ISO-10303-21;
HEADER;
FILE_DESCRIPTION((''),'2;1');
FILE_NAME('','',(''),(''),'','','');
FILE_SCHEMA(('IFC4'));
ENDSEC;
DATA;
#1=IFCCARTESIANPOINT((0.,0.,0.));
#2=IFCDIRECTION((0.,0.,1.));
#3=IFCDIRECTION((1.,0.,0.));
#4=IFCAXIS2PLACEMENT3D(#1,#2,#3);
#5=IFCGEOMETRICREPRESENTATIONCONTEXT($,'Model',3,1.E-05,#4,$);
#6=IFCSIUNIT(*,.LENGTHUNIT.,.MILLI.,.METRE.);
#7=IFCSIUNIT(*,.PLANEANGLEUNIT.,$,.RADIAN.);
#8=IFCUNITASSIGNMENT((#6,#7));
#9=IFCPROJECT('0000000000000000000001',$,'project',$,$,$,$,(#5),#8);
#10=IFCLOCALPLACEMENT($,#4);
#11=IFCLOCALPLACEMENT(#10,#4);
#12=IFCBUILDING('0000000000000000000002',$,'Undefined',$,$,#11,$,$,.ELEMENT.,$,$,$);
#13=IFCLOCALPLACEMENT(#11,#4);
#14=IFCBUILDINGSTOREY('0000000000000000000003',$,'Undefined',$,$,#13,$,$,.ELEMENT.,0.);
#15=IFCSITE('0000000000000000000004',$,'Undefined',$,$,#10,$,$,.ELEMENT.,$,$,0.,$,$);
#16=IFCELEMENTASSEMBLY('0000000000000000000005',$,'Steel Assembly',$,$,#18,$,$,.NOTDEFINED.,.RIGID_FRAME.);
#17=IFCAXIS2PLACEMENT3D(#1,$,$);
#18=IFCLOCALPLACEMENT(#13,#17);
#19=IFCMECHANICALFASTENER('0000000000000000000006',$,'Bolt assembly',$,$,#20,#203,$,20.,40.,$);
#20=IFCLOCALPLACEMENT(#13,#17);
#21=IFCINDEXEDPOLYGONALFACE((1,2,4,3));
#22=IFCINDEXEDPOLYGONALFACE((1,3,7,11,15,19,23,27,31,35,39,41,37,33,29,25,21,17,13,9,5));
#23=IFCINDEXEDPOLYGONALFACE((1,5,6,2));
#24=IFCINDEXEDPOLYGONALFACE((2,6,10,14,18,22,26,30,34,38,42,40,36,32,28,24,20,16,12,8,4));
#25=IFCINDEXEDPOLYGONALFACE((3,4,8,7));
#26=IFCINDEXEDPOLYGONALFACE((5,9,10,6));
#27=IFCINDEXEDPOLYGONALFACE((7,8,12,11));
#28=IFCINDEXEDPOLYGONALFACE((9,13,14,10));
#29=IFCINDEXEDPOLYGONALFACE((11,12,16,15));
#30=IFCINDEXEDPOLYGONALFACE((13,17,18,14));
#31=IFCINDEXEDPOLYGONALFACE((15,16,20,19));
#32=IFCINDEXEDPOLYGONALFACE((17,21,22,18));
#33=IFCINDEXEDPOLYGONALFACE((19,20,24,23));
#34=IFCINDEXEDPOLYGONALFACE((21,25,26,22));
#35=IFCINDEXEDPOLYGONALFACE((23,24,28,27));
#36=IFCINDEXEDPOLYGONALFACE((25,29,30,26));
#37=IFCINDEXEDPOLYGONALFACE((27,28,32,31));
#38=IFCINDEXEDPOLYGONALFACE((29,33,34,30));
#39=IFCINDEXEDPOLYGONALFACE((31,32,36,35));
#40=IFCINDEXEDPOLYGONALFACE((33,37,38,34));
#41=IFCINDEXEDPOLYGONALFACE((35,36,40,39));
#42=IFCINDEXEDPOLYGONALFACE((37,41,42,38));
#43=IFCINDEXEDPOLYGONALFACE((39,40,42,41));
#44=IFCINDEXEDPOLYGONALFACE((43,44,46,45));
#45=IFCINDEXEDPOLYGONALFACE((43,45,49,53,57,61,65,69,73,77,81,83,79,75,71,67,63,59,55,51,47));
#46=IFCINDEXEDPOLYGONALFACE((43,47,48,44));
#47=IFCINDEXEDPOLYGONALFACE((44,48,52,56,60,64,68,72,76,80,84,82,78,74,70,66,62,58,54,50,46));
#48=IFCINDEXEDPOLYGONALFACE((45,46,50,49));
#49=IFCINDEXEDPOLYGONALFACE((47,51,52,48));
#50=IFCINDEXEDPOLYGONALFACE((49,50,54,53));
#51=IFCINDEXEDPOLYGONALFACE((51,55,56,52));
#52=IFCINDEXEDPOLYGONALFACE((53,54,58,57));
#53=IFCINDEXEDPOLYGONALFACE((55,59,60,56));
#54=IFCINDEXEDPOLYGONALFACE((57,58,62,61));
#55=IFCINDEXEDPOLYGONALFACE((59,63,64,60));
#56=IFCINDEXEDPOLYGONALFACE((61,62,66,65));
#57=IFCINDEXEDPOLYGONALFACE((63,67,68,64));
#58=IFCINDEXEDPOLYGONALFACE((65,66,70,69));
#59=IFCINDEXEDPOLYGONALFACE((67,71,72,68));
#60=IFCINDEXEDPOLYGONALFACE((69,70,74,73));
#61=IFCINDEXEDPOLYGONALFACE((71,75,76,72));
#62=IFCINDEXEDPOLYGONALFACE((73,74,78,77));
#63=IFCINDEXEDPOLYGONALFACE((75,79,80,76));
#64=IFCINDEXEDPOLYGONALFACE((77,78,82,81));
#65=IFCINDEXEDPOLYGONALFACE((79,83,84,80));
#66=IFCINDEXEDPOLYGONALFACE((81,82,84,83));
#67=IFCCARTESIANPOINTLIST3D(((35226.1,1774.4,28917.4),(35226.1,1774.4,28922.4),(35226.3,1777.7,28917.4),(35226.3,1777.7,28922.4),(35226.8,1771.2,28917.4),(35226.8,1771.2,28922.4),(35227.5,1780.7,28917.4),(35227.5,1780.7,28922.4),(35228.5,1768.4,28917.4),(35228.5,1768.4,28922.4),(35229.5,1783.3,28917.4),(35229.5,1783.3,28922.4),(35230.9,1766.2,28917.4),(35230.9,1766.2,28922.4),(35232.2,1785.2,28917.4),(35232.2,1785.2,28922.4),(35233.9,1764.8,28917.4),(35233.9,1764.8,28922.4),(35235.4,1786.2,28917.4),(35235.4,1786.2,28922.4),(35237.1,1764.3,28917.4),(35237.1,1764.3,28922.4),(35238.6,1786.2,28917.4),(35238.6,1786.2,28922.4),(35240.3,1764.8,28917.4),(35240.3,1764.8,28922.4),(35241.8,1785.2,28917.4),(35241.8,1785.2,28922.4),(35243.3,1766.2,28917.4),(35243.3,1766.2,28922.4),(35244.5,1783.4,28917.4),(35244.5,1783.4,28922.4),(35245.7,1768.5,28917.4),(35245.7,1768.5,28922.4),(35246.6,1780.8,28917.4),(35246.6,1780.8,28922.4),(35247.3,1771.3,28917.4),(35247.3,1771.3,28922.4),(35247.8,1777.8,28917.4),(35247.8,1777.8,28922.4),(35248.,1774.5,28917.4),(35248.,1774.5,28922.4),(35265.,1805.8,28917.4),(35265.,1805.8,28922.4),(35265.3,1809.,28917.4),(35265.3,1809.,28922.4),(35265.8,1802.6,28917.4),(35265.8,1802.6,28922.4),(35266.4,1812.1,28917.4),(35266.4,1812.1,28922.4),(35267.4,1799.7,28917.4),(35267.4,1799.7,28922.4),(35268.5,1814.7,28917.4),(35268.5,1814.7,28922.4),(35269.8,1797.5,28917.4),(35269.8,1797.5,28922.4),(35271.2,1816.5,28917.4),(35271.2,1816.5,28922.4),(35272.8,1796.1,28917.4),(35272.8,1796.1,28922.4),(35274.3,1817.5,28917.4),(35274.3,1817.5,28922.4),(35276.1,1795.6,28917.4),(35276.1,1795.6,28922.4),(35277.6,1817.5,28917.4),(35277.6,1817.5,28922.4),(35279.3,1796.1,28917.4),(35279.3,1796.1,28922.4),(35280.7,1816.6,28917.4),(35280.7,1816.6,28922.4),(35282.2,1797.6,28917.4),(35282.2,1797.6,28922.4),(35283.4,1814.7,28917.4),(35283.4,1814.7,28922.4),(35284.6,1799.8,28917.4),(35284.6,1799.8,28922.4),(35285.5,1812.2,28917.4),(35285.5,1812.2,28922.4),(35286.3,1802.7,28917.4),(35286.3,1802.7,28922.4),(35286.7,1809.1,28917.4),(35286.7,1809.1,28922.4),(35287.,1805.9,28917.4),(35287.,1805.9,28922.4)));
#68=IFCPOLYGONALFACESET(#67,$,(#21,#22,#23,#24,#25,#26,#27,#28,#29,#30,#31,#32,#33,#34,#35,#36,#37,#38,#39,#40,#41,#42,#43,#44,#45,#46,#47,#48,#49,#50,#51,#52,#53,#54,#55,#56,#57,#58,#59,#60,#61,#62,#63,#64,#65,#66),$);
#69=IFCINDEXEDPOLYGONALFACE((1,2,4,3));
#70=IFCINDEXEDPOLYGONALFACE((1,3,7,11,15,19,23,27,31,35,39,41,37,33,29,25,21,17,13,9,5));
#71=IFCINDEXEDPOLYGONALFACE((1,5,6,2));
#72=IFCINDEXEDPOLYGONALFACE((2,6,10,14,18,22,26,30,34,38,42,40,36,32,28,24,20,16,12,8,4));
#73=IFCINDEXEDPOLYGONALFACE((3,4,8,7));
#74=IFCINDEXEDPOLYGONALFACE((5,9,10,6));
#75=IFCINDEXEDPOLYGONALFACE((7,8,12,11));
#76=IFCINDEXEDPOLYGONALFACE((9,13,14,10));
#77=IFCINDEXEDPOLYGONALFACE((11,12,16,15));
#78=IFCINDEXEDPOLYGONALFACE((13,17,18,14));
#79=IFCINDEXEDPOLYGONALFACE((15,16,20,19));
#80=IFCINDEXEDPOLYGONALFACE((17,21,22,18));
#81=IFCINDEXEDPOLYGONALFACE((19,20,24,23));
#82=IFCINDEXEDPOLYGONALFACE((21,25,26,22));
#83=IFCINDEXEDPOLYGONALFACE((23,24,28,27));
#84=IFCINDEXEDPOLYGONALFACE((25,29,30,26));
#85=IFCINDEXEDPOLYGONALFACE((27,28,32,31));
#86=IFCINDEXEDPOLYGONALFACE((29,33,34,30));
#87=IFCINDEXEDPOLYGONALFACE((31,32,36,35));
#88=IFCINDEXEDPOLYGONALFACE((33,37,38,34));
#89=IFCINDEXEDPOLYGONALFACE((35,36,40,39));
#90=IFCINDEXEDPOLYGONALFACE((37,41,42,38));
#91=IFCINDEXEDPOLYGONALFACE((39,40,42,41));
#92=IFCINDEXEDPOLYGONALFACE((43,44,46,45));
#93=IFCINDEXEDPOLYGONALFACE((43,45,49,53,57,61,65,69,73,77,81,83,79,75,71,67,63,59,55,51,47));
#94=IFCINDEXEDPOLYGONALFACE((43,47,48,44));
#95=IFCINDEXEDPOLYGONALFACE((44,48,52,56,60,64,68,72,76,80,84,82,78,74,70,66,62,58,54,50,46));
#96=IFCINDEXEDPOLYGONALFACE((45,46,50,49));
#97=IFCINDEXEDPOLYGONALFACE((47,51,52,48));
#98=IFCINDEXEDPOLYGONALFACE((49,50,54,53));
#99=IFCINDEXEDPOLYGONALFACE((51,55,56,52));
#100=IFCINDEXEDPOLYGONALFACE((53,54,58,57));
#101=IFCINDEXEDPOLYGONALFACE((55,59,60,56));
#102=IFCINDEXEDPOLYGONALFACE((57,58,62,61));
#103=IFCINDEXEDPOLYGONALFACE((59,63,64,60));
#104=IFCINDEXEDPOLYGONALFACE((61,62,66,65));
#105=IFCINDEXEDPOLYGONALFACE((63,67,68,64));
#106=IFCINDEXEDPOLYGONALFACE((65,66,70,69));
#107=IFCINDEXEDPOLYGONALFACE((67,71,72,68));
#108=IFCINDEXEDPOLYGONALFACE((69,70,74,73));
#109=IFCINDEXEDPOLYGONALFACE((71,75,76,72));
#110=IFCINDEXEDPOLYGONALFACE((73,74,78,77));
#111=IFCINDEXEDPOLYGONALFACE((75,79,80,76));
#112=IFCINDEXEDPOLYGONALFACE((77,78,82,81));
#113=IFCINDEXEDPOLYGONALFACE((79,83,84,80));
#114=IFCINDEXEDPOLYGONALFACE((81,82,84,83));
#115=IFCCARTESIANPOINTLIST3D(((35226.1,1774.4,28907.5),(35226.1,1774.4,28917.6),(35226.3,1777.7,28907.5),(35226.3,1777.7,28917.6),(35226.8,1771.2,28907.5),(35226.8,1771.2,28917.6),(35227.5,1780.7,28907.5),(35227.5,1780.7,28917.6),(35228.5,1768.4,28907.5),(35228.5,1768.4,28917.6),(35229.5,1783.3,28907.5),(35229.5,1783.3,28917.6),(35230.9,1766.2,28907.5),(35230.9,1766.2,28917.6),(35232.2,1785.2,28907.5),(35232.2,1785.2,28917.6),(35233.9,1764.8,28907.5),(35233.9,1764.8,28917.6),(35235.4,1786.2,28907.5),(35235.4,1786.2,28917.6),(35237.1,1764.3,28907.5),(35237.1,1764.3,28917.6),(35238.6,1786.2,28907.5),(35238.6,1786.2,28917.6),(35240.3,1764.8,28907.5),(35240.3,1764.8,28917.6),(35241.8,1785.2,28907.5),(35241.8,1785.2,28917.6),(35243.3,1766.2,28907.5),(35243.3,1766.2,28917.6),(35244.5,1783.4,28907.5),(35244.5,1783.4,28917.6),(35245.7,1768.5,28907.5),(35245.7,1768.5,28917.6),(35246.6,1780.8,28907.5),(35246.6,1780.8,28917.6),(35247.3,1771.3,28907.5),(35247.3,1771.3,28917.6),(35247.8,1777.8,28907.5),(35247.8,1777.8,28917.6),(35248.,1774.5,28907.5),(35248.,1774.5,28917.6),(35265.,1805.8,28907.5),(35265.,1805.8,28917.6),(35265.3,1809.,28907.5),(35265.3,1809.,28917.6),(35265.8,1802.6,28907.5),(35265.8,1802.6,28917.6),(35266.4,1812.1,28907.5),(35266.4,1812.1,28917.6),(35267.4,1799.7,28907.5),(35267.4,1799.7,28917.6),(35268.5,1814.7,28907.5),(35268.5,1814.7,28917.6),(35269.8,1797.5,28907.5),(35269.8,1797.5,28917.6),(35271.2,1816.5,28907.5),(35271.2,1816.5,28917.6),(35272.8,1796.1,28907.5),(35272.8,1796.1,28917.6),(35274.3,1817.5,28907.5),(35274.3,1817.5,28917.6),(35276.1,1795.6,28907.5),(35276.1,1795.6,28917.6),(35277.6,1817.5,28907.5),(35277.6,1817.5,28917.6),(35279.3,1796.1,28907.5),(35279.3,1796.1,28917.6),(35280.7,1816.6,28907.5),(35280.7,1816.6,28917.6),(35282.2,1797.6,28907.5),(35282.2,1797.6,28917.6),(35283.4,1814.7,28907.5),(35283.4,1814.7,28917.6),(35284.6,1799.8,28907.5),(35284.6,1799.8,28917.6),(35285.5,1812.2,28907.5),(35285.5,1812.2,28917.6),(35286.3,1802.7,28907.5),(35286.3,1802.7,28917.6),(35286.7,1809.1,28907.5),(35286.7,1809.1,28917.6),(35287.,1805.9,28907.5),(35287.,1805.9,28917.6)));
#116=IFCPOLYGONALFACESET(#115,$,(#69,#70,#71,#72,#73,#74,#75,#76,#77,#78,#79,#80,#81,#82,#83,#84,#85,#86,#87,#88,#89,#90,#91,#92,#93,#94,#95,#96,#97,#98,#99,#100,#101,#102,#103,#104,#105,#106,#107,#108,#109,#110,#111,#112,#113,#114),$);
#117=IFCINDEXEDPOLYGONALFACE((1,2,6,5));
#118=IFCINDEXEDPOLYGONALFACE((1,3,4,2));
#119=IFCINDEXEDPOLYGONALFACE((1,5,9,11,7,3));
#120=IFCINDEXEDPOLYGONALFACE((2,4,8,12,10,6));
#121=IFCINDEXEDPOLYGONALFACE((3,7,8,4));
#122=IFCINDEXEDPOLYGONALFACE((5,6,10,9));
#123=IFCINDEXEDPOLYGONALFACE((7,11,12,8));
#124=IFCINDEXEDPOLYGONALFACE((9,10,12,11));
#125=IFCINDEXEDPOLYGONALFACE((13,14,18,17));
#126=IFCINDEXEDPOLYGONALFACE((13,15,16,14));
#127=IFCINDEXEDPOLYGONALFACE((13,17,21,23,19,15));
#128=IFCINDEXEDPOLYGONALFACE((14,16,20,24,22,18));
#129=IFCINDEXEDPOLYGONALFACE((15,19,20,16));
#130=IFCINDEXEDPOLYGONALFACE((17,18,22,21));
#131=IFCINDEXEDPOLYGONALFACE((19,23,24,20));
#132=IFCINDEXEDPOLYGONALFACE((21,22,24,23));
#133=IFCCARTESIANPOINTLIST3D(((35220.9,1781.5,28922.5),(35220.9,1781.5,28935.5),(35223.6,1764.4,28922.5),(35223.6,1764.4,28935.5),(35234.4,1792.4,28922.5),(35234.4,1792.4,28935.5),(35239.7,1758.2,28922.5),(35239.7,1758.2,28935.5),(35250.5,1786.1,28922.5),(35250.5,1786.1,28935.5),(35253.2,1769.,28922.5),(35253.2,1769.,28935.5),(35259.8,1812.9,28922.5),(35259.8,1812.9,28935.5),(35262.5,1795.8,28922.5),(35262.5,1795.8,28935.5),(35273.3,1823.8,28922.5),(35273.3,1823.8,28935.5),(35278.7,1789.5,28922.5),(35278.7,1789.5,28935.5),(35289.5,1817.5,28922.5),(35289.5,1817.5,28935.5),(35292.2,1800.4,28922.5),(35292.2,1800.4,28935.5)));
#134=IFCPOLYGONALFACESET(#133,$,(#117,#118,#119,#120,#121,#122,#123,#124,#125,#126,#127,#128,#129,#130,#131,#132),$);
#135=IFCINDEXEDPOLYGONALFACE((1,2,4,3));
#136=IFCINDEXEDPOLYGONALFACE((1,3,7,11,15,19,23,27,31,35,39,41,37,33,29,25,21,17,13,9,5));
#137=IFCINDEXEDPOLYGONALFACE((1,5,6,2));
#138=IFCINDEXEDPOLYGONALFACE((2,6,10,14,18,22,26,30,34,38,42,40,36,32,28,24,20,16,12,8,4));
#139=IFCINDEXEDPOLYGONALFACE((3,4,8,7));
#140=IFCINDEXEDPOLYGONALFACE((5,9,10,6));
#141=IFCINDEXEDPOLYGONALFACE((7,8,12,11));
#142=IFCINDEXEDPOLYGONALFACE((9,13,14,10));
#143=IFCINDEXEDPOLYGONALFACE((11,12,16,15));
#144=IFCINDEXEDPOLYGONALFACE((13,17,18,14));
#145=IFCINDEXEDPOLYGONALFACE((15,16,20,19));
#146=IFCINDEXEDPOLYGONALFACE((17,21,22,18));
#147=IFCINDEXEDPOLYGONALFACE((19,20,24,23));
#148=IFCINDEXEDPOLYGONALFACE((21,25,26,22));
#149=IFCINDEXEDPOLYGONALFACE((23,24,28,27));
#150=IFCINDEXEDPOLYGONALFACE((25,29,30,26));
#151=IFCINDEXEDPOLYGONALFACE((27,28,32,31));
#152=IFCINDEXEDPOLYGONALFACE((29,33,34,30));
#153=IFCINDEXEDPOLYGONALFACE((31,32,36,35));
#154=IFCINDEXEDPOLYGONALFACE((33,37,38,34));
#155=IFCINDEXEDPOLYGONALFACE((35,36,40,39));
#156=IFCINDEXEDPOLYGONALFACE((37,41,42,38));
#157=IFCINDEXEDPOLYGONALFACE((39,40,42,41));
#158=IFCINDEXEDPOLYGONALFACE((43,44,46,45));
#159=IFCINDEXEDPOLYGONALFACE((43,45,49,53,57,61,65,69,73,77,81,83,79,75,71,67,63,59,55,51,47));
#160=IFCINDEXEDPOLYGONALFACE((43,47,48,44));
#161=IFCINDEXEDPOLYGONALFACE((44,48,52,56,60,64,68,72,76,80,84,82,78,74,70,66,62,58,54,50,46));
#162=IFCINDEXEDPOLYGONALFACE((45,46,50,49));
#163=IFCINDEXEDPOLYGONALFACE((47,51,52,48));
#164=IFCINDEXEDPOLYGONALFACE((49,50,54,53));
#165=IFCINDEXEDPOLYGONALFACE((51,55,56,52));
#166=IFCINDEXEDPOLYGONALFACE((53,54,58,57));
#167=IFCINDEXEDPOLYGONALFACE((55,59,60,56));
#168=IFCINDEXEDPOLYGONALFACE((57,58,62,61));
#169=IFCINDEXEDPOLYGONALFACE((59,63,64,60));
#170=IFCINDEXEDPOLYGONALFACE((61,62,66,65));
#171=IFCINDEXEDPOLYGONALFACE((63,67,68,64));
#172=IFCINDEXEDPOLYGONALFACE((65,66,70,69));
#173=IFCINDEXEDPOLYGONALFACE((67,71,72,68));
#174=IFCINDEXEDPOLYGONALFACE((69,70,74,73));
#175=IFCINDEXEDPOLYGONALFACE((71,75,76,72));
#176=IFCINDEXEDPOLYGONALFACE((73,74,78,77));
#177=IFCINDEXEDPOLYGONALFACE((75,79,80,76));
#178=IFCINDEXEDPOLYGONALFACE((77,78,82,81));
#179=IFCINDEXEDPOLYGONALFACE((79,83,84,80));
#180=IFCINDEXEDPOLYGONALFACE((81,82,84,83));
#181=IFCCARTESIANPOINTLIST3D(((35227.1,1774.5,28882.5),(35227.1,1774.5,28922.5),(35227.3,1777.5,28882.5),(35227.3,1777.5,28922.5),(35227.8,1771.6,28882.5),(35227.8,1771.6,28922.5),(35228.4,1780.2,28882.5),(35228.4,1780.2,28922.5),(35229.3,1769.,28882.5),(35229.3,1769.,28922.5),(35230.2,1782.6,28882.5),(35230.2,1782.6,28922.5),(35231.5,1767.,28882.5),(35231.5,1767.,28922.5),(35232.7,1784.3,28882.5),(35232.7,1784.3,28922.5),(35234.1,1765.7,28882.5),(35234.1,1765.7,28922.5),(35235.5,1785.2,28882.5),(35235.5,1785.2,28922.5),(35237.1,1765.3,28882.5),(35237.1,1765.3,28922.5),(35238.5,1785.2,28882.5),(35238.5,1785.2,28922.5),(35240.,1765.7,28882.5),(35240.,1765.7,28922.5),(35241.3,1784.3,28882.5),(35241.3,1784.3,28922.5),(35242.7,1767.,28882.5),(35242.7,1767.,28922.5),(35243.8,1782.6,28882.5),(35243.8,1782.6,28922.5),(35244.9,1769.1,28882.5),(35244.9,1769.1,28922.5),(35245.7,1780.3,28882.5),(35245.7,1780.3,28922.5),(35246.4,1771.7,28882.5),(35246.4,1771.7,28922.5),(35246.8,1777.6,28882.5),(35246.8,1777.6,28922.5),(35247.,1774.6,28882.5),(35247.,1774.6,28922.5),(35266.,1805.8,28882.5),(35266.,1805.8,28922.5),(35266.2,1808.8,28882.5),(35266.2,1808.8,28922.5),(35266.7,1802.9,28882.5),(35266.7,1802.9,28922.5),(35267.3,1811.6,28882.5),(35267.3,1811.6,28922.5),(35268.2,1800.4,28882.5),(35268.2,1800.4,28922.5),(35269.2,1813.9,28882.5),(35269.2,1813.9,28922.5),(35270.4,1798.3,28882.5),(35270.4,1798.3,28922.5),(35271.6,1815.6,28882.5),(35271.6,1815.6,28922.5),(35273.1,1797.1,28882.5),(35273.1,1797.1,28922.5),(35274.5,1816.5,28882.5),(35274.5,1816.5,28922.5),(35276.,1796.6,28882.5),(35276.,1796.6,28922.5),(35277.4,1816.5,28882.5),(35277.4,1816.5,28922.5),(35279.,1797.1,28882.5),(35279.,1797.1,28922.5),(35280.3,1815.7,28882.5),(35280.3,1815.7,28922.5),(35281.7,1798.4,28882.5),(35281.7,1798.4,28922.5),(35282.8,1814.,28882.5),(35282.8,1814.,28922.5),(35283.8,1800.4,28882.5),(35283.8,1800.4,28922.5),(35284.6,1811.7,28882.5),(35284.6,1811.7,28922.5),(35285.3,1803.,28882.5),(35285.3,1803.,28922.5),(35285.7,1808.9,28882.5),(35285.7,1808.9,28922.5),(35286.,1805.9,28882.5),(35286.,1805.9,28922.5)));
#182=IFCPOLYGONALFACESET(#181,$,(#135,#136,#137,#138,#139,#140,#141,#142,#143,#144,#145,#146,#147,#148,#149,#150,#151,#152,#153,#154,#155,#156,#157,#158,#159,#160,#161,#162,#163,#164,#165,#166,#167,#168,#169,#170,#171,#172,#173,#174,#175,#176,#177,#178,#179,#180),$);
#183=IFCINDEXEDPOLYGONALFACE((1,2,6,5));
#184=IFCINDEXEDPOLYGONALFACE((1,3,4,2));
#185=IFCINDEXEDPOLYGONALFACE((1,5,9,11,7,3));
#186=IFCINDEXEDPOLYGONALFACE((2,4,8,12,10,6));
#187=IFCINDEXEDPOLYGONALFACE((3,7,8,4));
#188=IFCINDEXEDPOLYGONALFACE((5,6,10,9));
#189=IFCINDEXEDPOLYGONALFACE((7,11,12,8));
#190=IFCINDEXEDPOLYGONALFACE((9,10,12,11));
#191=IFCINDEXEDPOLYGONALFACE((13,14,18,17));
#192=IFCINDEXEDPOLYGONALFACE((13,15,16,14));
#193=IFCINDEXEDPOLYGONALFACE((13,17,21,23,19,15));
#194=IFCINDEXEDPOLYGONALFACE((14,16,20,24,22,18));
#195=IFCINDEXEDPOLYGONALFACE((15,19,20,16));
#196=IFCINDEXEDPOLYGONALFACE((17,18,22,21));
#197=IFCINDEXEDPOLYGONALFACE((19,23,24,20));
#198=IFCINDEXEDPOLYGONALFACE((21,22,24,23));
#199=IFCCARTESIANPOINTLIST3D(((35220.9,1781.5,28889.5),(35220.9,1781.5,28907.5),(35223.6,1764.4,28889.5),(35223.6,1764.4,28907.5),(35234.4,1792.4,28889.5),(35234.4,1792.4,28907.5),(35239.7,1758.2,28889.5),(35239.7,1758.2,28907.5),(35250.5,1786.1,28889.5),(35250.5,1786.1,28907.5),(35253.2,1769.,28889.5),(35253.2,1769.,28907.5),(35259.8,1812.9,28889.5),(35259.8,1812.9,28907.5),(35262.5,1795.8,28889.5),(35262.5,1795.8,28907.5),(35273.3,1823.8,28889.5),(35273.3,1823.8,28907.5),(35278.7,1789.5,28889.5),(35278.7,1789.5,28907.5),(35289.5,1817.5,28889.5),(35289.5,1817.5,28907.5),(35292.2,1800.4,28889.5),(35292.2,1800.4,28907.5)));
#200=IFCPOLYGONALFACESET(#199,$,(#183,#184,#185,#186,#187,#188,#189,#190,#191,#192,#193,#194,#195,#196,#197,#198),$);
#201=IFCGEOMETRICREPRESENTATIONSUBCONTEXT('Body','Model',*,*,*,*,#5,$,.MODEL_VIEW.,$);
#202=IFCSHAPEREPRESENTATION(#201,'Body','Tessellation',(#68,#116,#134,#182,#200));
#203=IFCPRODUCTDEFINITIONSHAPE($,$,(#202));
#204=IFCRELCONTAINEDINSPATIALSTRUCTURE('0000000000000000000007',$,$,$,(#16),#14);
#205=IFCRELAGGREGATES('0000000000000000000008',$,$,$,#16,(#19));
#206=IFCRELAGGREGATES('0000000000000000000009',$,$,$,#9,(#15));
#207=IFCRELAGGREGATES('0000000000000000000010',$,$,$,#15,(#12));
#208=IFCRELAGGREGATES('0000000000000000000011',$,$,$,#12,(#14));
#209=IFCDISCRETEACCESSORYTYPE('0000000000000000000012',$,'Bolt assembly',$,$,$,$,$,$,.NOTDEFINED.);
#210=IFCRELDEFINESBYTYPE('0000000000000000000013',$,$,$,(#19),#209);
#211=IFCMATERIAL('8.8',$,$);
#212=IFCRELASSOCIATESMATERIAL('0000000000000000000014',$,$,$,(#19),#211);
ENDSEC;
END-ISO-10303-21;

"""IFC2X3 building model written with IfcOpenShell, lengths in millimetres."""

from ifc_helpers import new_model, si_unit, frame, origin_with_axes, origin_2d_with_axis, place, context, subcontext, project, spatial, polyline, circle, outline, extrude, source, transform, mapped, material, type_object, element, aggregate, save


model = new_model("IFC2X3")

# Units and contexts
model_context = context("Model", 3, precision=1e-05, world=origin_with_axes())
body_context = subcontext(model_context, "Body", "Model", "MODEL_VIEW")
ifc_project = project(units=[si_unit("LENGTHUNIT", "METRE", prefix="MILLI"), si_unit("PLANEANGLEUNIT", "RADIAN")], contexts=[model_context])

# Site, building, storey
site_placement = place(None, origin_with_axes())
site = spatial("IfcSite", under=ifc_project, at=site_placement, Name="Undefined", CompositionType="ELEMENT", RefElevation=0.0)
building_placement = place(site_placement, origin_with_axes())
building = spatial("IfcBuilding", under=site, at=building_placement, Name="Undefined", CompositionType="ELEMENT")
storey_placement = place(building_placement, origin_with_axes())
storey = spatial("IfcBuildingStorey", under=building, at=storey_placement, Name="Undefined", CompositionType="ELEMENT", Elevation=0.0)

# Shared definitions
discrete_accessory_type_1 = type_object("IfcDiscreteAccessoryType", Name="Bolt assembly")
ifc_material_1 = material(Name="8.8")

# Shared definitions
shared_shape_1 = source(origin_with_axes(), body_context, "Body", "SweptSolid", [
    extrude(circle(Radius=11.0, at=origin_2d_with_axis()), frame((0.0, 0.1, 0.0), z_axis=(0.0, 1.0, 0.0), x_axis=(1.0, 0.0, 0.0)), (0.0, 0.0, 1.0), 5.0),
    extrude(circle(Radius=11.0, at=origin_2d_with_axis()), frame((0.0, 4.9, 0.0), z_axis=(0.0, 1.0, 0.0), x_axis=(1.0, 0.0, 0.0)), (0.0, 0.0, 1.0), 10.1),
    extrude(outline(polyline([(17.3, 0.0), (8.7, 15.0), (-8.7, 15.0), (-17.3, 0.0), (-8.7, -15.0), (8.7, -15.0), (17.3, 0.0)])), frame((0.0, -13.0, 0.0), z_axis=(0.0, 1.0, 0.0), x_axis=(1.0, 0.0, 0.0)), (0.0, 0.0, 1.0), 13.0),
    extrude(circle(Radius=10.0, at=origin_2d_with_axis()), frame((0.0, 0.0, 0.0), z_axis=(0.0, 1.0, 0.0), x_axis=(1.0, 0.0, 0.0)), (0.0, 0.0, 1.0), 40.0),
    extrude(outline(polyline([(17.3, 0.0), (8.7, 15.0), (-8.7, 15.0), (-17.3, 0.0), (-8.7, -15.0), (8.7, -15.0), (17.3, 0.0)])), frame((0.0, 15.0, 0.0), z_axis=(0.0, 1.0, 0.0), x_axis=(1.0, 0.0, 0.0)), (0.0, 0.0, 1.0), 18.0),
])

# Element assembly, mechanical fastener
assembly_1_placement = place(storey_placement, origin_with_axes())
assembly_1 = element("IfcElementAssembly", 1, at=assembly_1_placement, inside=storey, Name="Steel Assembly", AssemblyPlace="NOTDEFINED", PredefinedType="RIGID_FRAME")
mechanical_fastener_1_placement = place(assembly_1_placement, frame((35276.0, 1806.6, 28922.5), z_axis=(0.627081, -0.778954, 0.0), x_axis=(-0.778954, -0.627081, 0.0)))
mechanical_fastener_1 = element("IfcMechanicalFastener", 2, at=mechanical_fastener_1_placement, type_object=discrete_accessory_type_1, material=ifc_material_1, Name="Bolt assembly", NominalDiameter=20.0, NominalLength=40.0, context=body_context, shape_type="MappedRepresentation", body=[
    mapped(shared_shape_1, transform((0.0, 0.0, 0.0))),
    mapped(shared_shape_1, transform((50.0, 0.0, 0.0))),
])
aggregate(assembly_1, [mechanical_fastener_1])

save(model, "model.ifc")
